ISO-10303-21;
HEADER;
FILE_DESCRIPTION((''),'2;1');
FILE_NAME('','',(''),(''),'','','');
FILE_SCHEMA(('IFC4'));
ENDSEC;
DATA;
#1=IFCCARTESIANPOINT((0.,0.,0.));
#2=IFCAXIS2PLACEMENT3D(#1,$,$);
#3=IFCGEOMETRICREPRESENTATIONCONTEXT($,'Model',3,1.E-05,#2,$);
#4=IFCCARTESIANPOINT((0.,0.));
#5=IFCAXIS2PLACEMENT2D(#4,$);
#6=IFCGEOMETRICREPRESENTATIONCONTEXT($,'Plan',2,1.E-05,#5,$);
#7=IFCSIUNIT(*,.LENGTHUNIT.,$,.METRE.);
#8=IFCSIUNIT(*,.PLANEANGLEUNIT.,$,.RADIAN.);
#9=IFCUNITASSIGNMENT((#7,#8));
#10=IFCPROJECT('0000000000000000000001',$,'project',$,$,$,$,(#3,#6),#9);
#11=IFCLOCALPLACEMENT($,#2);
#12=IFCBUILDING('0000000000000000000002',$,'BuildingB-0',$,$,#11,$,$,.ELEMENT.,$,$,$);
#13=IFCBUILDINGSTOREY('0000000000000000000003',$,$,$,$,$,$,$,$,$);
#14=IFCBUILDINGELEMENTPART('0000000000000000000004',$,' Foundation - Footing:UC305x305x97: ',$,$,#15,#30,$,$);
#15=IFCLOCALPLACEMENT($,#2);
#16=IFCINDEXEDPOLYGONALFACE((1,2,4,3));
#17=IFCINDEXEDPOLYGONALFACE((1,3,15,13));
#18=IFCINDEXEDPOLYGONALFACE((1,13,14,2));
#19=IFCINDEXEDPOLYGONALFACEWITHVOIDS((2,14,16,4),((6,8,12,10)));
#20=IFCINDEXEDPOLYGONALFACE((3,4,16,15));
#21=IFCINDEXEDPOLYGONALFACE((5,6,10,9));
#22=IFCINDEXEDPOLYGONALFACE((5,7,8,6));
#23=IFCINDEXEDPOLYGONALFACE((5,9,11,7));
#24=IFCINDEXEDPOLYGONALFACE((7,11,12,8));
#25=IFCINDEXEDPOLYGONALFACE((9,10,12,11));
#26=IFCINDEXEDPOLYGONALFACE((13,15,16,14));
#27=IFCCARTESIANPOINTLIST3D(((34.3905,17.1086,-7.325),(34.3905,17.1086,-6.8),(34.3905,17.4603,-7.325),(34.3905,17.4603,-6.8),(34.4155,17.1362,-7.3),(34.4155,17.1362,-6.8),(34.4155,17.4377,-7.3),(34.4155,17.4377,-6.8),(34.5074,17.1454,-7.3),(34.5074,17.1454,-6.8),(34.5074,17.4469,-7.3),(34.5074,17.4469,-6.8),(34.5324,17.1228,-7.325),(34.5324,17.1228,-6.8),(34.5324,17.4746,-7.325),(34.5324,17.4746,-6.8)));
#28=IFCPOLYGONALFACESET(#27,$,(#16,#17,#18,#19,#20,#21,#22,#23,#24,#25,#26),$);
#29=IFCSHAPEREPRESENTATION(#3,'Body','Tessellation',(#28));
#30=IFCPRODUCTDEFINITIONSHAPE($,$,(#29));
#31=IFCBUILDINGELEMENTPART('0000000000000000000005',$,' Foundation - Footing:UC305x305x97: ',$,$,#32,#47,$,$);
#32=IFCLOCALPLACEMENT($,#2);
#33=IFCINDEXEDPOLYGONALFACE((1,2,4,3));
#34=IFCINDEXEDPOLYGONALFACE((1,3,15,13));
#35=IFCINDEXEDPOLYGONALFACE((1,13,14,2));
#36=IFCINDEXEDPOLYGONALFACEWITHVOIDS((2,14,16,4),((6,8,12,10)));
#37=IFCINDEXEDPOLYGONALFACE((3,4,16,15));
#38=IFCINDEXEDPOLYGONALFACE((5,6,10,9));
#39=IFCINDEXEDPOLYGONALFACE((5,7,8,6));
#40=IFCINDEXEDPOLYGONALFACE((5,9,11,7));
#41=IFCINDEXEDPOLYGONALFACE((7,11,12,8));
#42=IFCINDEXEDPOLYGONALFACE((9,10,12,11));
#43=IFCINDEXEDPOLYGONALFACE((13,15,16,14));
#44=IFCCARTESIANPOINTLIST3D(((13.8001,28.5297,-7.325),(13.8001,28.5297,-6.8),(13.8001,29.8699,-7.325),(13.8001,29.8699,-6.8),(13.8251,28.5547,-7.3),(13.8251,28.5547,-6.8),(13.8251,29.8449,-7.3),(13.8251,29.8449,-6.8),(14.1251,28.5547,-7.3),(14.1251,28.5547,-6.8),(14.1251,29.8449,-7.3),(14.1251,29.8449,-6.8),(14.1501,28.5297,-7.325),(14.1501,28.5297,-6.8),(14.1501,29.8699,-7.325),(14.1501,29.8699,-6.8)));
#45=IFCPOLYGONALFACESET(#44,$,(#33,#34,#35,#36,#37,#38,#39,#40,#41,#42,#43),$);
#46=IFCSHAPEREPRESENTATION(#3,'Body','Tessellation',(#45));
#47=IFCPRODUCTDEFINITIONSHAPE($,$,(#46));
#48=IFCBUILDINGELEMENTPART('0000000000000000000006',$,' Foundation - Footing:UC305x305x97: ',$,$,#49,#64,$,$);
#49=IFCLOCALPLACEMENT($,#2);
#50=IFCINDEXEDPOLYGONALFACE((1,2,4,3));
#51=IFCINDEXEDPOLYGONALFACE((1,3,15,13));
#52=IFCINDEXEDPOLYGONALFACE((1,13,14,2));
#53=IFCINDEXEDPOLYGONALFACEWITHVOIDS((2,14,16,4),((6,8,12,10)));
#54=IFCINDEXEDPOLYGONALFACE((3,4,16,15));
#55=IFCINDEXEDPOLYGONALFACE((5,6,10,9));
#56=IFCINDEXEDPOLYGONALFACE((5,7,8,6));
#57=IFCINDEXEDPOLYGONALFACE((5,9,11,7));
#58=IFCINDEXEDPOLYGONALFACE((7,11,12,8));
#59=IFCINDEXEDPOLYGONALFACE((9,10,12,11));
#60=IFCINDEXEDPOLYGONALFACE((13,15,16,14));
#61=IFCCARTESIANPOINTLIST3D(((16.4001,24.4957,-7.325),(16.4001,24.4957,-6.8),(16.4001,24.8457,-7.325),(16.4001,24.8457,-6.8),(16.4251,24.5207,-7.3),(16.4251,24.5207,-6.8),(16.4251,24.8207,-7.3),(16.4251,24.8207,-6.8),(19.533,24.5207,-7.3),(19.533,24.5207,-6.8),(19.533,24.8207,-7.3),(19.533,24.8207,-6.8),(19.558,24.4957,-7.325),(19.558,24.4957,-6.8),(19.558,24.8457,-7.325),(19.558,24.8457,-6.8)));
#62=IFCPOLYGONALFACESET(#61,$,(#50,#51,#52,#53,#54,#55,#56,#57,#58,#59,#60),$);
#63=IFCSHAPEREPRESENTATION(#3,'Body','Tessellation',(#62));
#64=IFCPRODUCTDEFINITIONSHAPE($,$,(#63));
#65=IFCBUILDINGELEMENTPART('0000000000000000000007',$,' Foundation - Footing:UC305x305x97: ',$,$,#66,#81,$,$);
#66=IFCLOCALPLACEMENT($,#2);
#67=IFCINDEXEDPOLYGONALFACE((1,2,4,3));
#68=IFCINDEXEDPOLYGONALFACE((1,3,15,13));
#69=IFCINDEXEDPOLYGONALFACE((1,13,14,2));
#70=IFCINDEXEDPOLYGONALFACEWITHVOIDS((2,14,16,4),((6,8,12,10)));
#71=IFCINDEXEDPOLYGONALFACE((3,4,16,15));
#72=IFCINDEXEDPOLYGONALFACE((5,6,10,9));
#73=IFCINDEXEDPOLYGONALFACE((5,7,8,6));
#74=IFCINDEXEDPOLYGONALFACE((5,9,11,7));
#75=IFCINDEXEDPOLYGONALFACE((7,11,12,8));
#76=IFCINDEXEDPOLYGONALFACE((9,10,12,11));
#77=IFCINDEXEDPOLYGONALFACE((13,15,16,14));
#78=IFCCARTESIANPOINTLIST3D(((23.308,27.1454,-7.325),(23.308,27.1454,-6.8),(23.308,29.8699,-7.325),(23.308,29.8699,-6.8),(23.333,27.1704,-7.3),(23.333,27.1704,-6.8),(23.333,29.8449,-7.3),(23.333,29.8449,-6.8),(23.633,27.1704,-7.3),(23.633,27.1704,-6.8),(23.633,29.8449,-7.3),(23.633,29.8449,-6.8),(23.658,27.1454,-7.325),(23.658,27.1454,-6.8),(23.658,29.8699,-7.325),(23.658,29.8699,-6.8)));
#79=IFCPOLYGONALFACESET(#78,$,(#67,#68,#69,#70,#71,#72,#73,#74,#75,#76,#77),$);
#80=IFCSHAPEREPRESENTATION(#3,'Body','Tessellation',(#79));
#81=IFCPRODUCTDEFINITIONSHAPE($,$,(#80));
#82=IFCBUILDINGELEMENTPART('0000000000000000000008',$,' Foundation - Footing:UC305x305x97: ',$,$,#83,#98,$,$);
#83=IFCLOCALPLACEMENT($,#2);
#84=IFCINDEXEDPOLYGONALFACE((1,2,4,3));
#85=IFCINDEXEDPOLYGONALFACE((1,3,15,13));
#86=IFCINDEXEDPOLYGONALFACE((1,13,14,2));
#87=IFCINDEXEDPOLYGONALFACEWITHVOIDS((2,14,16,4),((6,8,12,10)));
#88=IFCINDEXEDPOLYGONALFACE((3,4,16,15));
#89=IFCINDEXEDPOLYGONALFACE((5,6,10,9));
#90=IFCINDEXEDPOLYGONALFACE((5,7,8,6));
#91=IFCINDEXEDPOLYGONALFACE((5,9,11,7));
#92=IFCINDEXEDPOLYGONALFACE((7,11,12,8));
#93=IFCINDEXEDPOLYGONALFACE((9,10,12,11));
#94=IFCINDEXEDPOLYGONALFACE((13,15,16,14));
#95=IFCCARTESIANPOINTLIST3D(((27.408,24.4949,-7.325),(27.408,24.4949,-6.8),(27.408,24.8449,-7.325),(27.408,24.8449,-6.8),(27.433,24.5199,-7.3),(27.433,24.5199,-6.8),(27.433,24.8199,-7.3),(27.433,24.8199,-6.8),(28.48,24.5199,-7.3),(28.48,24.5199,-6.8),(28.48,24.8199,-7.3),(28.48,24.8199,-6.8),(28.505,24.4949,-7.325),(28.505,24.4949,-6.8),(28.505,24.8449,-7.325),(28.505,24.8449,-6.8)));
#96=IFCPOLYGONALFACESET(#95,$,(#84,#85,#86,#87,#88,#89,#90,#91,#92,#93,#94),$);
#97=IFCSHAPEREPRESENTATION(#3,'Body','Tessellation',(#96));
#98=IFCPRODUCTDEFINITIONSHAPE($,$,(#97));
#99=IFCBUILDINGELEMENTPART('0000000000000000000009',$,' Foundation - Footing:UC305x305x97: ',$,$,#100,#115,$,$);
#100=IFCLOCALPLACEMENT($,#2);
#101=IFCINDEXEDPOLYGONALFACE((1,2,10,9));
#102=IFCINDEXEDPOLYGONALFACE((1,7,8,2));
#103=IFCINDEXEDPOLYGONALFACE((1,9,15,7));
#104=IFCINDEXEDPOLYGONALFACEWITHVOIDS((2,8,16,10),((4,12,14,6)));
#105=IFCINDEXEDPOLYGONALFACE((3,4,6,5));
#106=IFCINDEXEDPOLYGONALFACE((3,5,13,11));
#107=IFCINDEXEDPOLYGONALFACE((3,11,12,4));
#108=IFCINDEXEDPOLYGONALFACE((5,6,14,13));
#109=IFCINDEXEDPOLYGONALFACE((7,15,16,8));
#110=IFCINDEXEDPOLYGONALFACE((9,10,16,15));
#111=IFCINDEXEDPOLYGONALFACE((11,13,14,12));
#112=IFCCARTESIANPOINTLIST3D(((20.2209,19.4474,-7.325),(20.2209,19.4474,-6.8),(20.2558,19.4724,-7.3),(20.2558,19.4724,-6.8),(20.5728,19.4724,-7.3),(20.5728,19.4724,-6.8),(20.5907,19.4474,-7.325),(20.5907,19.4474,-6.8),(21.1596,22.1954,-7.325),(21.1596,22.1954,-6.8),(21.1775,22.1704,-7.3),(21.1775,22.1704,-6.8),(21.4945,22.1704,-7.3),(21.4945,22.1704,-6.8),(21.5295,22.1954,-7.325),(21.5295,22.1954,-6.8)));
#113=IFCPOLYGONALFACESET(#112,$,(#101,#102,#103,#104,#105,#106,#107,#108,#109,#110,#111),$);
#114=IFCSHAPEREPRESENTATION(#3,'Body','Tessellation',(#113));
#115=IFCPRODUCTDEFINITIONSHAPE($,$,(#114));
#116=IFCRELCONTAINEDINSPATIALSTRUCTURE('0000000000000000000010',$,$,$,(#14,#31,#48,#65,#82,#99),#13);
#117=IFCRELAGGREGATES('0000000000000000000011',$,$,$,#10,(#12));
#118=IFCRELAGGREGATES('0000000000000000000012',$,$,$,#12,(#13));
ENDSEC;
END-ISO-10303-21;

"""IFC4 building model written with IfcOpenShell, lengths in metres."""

from ifc_helpers import new_model, si_unit, origin, origin_2d, place, context, project, spatial, polyline, outline, extrude, element, save


model = new_model("IFC4")

# Units and contexts
model_context = context("Model", 3, precision=1e-05, world=origin())
plan_context = context("Plan", 2, precision=1e-05, world=origin_2d())
ifc_project = project(units=[si_unit("LENGTHUNIT", "METRE"), si_unit("PLANEANGLEUNIT", "RADIAN")], contexts=[model_context, plan_context])

# Building, storey
building_placement = place(None, origin())
building = spatial("IfcBuilding", under=ifc_project, at=building_placement, Name="BuildingB-0", CompositionType="ELEMENT")
storey = spatial("IfcBuildingStorey", under=building)

# Building element parts, openings
building_element_part_1 = element("IfcBuildingElementPart", 1, inside=storey, Name=" Foundation - Footing:UC305x305x97: ", context=model_context, shape_type="SweptSolid", body=[
    extrude(outline(polyline([(34.3905, 17.1086, -7.325), (34.5324, 17.1228, -7.325), (34.5324, 17.4746, -7.325), (34.3905, 17.4603, -7.325), (34.3905, 17.1086, -7.325)])), None, (0.0, 0.0, 1.0), 0.525),
])
element("IfcOpeningElement", 2, inside=storey, cuts=building_element_part_1, context=model_context, shape_type="SweptSolid", body=[
    extrude(outline(polyline([(34.4155, 17.1362, -7.3), (34.5074, 17.1454, -7.3), (34.5074, 17.4469, -7.3), (34.4155, 17.4377, -7.3), (34.4155, 17.1362, -7.3)])), None, (0.0, 0.0, 1.0), 0.5),
])
building_element_part_2 = element("IfcBuildingElementPart", 3, inside=storey, Name=" Foundation - Footing:UC305x305x97: ", context=model_context, shape_type="SweptSolid", body=[
    extrude(outline(polyline([(13.8001, 28.5297, -7.325), (14.1501, 28.5297, -7.325), (14.1501, 29.8699, -7.325), (13.8001, 29.8699, -7.325), (13.8001, 28.5297, -7.325)])), None, (0.0, 0.0, 1.0), 0.525),
])
element("IfcOpeningElement", 4, inside=storey, cuts=building_element_part_2, context=model_context, shape_type="SweptSolid", body=[
    extrude(outline(polyline([(13.8251, 28.5547, -7.3), (14.1251, 28.5547, -7.3), (14.1251, 29.8449, -7.3), (13.8251, 29.8449, -7.3), (13.8251, 28.5547, -7.3)])), None, (0.0, 0.0, 1.0), 0.5),
])
building_element_part_3 = element("IfcBuildingElementPart", 5, inside=storey, Name=" Foundation - Footing:UC305x305x97: ", context=model_context, shape_type="SweptSolid", body=[
    extrude(outline(polyline([(16.4001, 24.4957, -7.325), (16.4001, 24.8457, -7.325), (19.558, 24.8457, -7.325), (19.558, 24.4957, -7.325), (16.4001, 24.4957, -7.325)])), None, (0.0, 0.0, 1.0), 0.525),
])
element("IfcOpeningElement", 6, inside=storey, cuts=building_element_part_3, context=model_context, shape_type="SweptSolid", body=[
    extrude(outline(polyline([(16.4251, 24.5207, -7.3), (16.4251, 24.8207, -7.3), (19.533, 24.8207, -7.3), (19.533, 24.5207, -7.3), (16.4251, 24.5207, -7.3)])), None, (0.0, 0.0, 1.0), 0.5),
])
building_element_part_4 = element("IfcBuildingElementPart", 7, inside=storey, Name=" Foundation - Footing:UC305x305x97: ", context=model_context, shape_type="SweptSolid", body=[
    extrude(outline(polyline([(23.308, 27.1454, -7.325), (23.658, 27.1454, -7.325), (23.658, 29.8699, -7.325), (23.308, 29.8699, -7.325), (23.308, 27.1454, -7.325)])), None, (0.0, 0.0, 1.0), 0.525),
])
element("IfcOpeningElement", 8, inside=storey, cuts=building_element_part_4, context=model_context, shape_type="SweptSolid", body=[
    extrude(outline(polyline([(23.333, 27.1704, -7.3), (23.633, 27.1704, -7.3), (23.633, 29.8449, -7.3), (23.333, 29.8449, -7.3), (23.333, 27.1704, -7.3)])), None, (0.0, 0.0, 1.0), 0.5),
])
building_element_part_5 = element("IfcBuildingElementPart", 9, inside=storey, Name=" Foundation - Footing:UC305x305x97: ", context=model_context, shape_type="SweptSolid", body=[
    extrude(outline(polyline([(27.408, 24.4949, -7.325), (27.408, 24.8449, -7.325), (28.505, 24.8449, -7.325), (28.505, 24.4949, -7.325), (27.408, 24.4949, -7.325)])), None, (0.0, 0.0, 1.0), 0.525),
])
element("IfcOpeningElement", 10, inside=storey, cuts=building_element_part_5, context=model_context, shape_type="SweptSolid", body=[
    extrude(outline(polyline([(27.433, 24.5199, -7.3), (27.433, 24.8199, -7.3), (28.48, 24.8199, -7.3), (28.48, 24.5199, -7.3), (27.433, 24.5199, -7.3)])), None, (0.0, 0.0, 1.0), 0.5),
])
building_element_part_6 = element("IfcBuildingElementPart", 11, inside=storey, Name=" Foundation - Footing:UC305x305x97: ", context=model_context, shape_type="SweptSolid", body=[
    extrude(outline(polyline([(20.2209, 19.4474, -7.325), (20.5907, 19.4474, -7.325), (21.5295, 22.1954, -7.325), (21.1596, 22.1954, -7.325), (20.2209, 19.4474, -7.325)])), None, (0.0, 0.0, 1.0), 0.525),
])
element("IfcOpeningElement", 12, inside=storey, cuts=building_element_part_6, context=model_context, shape_type="SweptSolid", body=[
    extrude(outline(polyline([(20.2558, 19.4724, -7.3), (20.5728, 19.4724, -7.3), (21.4945, 22.1704, -7.3), (21.1775, 22.1704, -7.3), (20.2558, 19.4724, -7.3)])), None, (0.0, 0.0, 1.0), 0.5),
])

save(model, "model.ifc")
